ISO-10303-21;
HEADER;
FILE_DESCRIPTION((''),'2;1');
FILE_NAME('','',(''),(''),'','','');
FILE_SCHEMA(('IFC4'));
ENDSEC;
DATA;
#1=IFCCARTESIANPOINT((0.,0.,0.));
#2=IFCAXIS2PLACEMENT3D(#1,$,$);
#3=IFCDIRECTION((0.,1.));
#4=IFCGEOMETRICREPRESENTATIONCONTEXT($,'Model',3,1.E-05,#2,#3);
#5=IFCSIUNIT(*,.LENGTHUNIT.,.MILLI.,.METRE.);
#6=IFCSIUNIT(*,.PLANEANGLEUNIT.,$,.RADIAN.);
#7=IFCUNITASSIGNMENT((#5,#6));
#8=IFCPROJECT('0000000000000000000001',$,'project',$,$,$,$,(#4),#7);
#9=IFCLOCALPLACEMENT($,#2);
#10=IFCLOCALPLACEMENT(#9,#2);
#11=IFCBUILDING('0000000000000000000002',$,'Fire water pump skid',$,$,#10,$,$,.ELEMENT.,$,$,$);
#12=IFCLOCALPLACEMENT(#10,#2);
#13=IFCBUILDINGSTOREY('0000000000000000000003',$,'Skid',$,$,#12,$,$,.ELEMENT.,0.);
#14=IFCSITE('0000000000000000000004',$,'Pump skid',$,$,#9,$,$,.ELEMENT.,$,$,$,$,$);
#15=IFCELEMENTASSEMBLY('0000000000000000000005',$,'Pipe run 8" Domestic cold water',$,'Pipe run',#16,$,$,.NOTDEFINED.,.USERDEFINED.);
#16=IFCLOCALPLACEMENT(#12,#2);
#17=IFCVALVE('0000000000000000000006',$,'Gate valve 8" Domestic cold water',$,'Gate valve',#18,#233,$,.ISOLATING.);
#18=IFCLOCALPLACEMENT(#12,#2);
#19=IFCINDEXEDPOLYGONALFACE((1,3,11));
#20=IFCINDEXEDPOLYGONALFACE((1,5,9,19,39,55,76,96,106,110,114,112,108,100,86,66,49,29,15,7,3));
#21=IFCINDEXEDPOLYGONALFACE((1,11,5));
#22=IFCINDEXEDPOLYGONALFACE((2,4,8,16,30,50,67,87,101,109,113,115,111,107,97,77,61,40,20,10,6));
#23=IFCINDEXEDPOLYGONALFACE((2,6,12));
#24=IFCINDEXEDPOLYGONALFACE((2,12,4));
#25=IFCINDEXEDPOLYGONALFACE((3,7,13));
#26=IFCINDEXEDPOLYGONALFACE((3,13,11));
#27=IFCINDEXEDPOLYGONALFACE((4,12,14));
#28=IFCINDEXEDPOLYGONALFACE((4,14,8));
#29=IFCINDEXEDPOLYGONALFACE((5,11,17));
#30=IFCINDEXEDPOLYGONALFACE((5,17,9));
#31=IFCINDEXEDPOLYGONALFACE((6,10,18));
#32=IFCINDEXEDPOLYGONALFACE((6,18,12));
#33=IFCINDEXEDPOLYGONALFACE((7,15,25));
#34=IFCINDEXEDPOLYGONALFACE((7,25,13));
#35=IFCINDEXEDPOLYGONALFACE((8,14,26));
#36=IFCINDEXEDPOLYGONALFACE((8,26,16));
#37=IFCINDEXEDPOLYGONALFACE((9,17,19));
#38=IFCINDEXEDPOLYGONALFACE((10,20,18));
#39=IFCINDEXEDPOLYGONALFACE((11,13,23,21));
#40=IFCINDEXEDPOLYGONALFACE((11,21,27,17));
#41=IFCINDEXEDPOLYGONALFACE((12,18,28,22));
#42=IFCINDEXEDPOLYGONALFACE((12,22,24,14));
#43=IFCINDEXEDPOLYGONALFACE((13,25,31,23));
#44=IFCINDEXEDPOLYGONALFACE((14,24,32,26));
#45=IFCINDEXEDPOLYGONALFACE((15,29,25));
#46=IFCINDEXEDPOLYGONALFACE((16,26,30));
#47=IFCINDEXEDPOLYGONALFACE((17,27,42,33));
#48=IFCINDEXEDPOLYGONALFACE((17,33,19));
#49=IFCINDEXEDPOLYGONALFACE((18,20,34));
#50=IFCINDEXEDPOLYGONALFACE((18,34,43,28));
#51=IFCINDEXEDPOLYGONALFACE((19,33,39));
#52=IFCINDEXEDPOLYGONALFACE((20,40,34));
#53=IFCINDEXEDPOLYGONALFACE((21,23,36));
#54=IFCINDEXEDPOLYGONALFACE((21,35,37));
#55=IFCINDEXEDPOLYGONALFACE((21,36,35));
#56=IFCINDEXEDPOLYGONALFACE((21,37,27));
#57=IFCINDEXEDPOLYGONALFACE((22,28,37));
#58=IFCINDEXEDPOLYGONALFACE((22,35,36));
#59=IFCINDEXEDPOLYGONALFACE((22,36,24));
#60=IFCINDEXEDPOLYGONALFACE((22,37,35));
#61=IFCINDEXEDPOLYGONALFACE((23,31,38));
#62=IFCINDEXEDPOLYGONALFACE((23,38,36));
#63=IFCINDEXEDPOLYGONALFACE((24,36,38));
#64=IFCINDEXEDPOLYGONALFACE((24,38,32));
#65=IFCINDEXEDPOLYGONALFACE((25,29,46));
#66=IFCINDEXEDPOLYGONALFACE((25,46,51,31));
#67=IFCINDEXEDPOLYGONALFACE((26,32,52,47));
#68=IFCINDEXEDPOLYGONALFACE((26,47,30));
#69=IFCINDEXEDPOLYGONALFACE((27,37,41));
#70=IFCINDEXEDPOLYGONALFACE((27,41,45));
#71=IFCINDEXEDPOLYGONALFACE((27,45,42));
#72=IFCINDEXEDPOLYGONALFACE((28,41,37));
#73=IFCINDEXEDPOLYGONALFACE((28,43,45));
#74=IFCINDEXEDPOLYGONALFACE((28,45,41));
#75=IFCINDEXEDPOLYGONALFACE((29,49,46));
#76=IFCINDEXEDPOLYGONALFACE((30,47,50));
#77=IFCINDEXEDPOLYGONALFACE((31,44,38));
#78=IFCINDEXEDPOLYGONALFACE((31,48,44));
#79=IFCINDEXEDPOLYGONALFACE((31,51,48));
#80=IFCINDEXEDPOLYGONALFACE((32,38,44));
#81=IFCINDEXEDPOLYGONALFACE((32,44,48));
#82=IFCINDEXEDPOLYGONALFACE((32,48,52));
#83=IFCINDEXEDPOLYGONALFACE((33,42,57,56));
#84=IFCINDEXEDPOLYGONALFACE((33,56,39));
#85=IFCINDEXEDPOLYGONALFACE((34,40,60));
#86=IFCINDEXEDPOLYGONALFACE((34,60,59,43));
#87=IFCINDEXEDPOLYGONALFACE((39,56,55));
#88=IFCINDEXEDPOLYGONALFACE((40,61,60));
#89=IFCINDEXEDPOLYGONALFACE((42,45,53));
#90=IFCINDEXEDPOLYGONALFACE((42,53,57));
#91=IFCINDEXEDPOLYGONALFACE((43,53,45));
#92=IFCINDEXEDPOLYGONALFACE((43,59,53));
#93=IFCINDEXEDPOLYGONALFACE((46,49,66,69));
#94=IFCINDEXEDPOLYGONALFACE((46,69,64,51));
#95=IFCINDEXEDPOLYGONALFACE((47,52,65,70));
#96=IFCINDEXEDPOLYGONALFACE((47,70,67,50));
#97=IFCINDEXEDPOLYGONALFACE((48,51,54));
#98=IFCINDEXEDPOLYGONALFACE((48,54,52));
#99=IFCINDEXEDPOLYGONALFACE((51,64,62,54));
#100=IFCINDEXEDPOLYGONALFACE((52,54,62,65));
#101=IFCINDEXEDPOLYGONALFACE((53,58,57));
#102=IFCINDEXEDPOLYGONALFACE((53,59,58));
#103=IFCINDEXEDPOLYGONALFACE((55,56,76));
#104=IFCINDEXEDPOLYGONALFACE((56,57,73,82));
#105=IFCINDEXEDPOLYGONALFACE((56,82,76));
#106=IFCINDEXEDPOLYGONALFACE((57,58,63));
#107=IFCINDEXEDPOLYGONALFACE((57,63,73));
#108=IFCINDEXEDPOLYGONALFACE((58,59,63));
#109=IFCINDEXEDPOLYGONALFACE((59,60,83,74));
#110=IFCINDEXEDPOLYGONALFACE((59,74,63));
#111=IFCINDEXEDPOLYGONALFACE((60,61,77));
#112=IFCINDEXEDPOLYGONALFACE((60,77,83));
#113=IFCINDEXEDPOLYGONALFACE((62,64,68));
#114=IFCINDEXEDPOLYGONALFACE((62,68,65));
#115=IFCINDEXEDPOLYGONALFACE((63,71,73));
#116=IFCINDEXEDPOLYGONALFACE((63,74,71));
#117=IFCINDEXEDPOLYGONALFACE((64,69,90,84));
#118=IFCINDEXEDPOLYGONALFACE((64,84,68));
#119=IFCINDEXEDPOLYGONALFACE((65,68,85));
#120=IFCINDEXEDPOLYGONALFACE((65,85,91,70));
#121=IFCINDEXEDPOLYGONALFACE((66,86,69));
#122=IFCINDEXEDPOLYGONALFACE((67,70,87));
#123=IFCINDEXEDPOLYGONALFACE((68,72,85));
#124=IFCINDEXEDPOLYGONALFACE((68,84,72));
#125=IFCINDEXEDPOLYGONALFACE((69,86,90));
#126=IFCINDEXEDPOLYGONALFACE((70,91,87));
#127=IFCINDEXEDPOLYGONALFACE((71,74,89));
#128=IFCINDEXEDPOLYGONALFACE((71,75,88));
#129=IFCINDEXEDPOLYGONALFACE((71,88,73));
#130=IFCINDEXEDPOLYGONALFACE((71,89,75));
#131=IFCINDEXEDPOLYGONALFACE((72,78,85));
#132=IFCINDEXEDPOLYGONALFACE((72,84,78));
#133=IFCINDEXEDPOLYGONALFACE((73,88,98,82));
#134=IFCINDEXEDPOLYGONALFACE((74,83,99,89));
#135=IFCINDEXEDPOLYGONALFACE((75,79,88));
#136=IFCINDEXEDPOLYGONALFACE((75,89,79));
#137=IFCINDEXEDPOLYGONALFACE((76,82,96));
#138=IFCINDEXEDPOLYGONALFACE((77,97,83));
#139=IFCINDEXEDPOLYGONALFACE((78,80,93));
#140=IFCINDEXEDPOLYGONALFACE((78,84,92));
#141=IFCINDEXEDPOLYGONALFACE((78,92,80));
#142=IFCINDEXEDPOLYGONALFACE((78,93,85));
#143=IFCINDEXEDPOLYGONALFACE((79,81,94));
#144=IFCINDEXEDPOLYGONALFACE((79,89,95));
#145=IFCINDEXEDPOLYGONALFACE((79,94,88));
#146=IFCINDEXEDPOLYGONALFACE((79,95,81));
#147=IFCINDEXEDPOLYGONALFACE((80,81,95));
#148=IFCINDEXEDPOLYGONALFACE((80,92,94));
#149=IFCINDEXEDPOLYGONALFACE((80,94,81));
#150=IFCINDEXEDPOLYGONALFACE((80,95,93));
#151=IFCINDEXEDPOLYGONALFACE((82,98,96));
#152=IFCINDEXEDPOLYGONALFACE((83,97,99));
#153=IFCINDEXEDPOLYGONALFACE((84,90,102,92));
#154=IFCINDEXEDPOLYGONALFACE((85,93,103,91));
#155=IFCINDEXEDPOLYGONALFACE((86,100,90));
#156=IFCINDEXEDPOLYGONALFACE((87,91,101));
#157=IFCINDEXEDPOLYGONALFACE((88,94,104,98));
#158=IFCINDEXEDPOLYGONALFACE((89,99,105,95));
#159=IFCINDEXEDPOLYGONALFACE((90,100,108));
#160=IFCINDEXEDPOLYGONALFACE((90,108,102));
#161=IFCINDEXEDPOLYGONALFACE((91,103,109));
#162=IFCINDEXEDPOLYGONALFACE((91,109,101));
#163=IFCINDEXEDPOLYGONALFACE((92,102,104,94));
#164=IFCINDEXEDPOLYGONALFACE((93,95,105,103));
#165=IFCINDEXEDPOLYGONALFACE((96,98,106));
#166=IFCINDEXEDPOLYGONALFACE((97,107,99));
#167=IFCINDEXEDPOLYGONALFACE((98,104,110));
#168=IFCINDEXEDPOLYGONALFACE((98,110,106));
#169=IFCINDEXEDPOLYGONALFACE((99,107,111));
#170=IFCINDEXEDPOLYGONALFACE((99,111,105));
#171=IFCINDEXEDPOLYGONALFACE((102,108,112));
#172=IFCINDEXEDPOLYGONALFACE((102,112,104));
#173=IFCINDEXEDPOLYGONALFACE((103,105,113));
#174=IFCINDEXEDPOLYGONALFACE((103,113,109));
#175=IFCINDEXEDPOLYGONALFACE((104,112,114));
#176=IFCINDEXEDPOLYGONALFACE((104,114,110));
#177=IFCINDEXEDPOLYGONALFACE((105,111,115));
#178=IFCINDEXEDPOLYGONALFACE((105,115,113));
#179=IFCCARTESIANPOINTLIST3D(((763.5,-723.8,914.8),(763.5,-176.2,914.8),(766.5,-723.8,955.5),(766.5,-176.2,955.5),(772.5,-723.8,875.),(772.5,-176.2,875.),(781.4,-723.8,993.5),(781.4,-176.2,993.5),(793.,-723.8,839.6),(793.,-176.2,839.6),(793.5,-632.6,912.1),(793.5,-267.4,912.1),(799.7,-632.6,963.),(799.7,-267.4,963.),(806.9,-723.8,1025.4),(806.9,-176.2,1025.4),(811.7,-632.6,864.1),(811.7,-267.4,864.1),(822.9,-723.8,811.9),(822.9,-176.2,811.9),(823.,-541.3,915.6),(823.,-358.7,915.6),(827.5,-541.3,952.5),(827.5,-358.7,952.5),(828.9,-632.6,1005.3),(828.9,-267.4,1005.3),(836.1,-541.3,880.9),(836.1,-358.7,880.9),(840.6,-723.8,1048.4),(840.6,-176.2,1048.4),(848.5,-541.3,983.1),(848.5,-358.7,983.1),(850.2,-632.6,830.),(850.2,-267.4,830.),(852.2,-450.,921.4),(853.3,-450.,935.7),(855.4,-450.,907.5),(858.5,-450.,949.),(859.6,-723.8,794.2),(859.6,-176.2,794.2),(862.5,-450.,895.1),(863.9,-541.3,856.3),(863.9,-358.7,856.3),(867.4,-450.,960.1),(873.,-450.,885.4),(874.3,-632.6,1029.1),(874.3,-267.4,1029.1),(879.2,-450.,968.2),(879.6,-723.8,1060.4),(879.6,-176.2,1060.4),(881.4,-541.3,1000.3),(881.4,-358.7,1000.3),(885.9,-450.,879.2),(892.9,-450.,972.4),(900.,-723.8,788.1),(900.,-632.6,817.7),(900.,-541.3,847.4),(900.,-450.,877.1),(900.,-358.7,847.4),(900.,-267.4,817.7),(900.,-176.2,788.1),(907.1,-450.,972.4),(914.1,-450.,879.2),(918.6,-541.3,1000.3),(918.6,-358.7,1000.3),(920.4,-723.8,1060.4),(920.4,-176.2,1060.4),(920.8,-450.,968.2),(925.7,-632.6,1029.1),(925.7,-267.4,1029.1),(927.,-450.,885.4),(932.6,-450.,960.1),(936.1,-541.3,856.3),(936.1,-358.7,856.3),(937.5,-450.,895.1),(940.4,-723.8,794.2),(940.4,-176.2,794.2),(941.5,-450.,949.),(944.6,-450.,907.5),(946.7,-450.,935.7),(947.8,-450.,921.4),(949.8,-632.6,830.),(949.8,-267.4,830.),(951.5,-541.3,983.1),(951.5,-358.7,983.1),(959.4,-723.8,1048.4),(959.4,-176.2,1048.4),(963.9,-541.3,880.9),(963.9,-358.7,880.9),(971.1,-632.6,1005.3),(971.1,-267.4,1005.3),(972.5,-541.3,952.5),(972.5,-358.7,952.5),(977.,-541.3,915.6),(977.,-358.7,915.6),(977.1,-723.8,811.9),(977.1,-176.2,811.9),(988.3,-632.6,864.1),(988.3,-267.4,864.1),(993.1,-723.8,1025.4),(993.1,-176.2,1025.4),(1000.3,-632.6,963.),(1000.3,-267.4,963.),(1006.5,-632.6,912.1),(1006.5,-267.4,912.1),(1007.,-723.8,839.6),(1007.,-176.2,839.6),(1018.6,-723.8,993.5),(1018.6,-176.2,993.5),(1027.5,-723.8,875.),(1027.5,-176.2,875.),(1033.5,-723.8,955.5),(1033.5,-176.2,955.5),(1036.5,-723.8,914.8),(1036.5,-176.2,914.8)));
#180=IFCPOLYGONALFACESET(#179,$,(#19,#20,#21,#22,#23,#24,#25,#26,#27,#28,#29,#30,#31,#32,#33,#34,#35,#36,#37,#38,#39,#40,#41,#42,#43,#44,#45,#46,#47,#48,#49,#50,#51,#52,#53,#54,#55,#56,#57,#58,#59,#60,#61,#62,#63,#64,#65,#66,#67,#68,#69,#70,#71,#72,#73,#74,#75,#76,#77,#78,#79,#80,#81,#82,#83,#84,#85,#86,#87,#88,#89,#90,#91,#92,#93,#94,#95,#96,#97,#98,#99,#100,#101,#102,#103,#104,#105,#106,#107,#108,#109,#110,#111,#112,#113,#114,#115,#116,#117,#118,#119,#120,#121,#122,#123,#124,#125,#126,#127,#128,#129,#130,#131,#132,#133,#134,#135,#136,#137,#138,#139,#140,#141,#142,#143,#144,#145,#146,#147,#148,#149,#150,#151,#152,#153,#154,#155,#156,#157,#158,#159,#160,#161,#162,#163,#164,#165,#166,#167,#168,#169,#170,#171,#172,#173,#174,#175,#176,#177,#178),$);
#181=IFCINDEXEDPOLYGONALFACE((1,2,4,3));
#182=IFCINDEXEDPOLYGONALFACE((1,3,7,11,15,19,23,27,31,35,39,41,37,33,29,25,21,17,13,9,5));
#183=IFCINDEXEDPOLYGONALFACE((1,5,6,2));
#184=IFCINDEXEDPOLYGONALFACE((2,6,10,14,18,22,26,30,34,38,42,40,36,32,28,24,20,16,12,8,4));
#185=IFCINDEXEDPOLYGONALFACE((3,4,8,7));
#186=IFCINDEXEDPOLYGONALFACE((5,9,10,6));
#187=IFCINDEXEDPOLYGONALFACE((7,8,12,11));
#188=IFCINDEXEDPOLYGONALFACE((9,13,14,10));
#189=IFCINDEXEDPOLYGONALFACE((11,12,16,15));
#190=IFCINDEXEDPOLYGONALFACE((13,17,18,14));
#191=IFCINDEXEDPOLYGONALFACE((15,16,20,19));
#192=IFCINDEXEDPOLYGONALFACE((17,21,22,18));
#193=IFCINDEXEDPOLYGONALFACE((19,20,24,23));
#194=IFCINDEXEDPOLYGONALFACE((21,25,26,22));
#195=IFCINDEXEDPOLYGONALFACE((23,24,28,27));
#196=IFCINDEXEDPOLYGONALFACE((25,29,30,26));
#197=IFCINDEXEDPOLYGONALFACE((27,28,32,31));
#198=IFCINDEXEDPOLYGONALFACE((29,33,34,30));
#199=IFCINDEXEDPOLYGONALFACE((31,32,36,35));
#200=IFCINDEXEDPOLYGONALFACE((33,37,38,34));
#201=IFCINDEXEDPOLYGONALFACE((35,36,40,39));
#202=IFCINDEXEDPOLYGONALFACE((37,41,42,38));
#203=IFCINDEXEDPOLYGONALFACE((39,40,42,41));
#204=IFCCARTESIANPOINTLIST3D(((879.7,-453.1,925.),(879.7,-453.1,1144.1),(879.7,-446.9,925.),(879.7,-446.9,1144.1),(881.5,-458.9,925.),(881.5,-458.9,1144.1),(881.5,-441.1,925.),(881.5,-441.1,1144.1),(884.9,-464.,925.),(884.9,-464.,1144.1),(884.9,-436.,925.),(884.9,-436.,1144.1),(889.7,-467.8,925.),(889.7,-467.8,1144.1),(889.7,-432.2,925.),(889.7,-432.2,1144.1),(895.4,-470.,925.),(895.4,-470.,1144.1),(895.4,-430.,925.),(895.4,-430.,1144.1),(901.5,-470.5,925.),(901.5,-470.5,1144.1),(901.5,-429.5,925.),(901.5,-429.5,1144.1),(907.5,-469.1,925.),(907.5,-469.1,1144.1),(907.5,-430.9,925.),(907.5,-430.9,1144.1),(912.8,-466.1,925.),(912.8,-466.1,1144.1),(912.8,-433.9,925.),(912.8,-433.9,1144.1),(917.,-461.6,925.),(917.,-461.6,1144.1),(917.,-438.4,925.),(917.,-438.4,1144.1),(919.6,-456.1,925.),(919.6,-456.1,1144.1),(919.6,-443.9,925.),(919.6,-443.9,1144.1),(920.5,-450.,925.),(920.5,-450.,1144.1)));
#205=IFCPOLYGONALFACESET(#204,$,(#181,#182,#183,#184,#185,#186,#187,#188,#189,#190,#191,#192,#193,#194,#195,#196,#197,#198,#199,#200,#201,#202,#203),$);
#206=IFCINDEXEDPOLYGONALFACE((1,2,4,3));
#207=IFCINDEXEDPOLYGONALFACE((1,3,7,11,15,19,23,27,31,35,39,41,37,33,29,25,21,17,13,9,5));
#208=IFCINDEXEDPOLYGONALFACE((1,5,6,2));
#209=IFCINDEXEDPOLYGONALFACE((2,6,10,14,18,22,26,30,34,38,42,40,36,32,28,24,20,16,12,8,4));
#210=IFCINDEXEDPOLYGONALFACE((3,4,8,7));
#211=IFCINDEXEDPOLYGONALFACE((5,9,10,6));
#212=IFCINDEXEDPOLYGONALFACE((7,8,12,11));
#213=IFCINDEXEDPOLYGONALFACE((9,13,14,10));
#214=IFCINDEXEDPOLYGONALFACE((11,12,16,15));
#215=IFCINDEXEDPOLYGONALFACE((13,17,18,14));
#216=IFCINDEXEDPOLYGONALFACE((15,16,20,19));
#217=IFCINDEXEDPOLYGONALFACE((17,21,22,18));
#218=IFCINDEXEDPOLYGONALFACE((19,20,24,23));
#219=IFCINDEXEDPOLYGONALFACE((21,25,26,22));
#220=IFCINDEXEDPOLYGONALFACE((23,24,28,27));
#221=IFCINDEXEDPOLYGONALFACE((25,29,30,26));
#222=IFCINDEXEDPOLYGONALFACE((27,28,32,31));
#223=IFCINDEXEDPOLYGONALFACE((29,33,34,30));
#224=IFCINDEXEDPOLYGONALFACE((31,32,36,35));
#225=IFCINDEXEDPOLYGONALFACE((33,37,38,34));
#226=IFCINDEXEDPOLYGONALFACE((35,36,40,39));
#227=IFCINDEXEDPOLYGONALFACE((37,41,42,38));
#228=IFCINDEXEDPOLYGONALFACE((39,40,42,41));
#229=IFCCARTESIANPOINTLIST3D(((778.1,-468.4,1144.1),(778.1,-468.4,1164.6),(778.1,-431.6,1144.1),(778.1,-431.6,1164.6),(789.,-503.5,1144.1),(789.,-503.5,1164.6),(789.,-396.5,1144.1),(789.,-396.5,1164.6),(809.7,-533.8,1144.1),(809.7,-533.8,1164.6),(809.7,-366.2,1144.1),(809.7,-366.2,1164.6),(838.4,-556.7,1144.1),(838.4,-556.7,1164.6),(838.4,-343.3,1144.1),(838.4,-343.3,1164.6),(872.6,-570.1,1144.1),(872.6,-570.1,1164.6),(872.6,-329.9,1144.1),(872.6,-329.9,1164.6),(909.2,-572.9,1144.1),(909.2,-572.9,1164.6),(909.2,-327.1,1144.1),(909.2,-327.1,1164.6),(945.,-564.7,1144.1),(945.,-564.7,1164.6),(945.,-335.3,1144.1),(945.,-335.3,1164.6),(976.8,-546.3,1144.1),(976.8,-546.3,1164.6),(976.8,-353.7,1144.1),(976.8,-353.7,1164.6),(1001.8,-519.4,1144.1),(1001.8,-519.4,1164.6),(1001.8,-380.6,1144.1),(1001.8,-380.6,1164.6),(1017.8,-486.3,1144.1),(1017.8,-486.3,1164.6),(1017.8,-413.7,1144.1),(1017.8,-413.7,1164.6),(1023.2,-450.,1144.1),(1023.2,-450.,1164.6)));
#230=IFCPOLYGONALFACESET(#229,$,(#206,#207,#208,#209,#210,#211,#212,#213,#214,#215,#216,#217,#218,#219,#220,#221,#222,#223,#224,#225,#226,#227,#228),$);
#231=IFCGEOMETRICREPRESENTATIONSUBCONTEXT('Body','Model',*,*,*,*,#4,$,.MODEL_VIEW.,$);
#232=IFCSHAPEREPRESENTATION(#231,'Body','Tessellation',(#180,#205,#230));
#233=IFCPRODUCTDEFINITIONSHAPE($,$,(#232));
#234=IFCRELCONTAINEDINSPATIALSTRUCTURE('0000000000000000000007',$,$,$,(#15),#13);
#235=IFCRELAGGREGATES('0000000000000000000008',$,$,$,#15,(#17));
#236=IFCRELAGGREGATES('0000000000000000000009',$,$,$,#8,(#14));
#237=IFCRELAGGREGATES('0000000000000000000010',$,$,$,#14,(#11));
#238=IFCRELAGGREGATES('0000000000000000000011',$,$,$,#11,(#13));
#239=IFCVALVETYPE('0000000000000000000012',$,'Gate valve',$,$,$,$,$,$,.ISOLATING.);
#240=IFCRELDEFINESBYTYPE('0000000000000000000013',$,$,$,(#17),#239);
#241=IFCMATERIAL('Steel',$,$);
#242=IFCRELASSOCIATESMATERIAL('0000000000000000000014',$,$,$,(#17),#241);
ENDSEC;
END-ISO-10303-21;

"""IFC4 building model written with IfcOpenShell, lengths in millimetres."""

from ifc_helpers import new_model, entity, si_unit, direction, frame, origin, origin_with_axes, origin_2d, place, context, subcontext, project, spatial, circle, extrude, material, type_object, element, aggregate, save


model = new_model("IFC4")

# Units and contexts
model_context = context("Model", 3, precision=1e-05, world=origin(), true_north=direction((0.0, 1.0)))
body_context = subcontext(model_context, "Body", "Model", "MODEL_VIEW")
ifc_project = project(units=[si_unit("LENGTHUNIT", "METRE", prefix="MILLI"), si_unit("PLANEANGLEUNIT", "RADIAN")], contexts=[model_context])

# Site, building, storey
site_placement = place(None, origin())
site = spatial("IfcSite", under=ifc_project, at=site_placement, Name="Pump skid", CompositionType="ELEMENT")
building_placement = place(site_placement, origin())
building = spatial("IfcBuilding", under=site, at=building_placement, Name="Fire water pump skid", CompositionType="ELEMENT")
storey_placement = place(building_placement, origin())
storey = spatial("IfcBuildingStorey", under=building, at=storey_placement, Name="Skid", CompositionType="ELEMENT", Elevation=0.0)

# Element assembly
ifc_material = material(Name="Steel")
assembly_1_placement = place(storey_placement, origin_with_axes())
assembly_1 = element("IfcElementAssembly", 1, at=assembly_1_placement, inside=storey, Name="Pipe run 8\" Domestic cold water", ObjectType="Pipe run", AssemblyPlace="NOTDEFINED", PredefinedType="USERDEFINED")

# Valve
valve_type_1 = type_object("IfcValveType", Name="Gate valve", PredefinedType="ISOLATING")
valve_1_placement = place(storey_placement, origin_with_axes())
cartesian_point_1 = entity("IfcCartesianPoint", [0.0, 0.0])
valve_1 = element("IfcValve", 2, at=valve_1_placement, type_object=valve_type_1, material=ifc_material, Name="Gate valve 8\" Domestic cold water", ObjectType="Gate valve", PredefinedType="ISOLATING", context=body_context, shape_type="SweptSolid", body=[
    entity("IfcRevolvedAreaSolid", entity("IfcArbitraryClosedProfileDef", "AREA", None, entity("IfcPolyline", [cartesian_point_1, entity("IfcCartesianPoint", [0.0, 136.9]), entity("IfcCartesianPoint", [273.8, 47.9]), entity("IfcCartesianPoint", [547.7, 136.9]), entity("IfcCartesianPoint", [547.7, 0.0]), cartesian_point_1])), entity("IfcAxis2Placement3D", entity("IfcCartesianPoint", [900.0, -723.8, 925.0]), entity("IfcDirection", [-1.0, 0.0, 0.0]), entity("IfcDirection", [0.0, 1.0, 0.0])), entity("IfcAxis1Placement", entity("IfcCartesianPoint", [0.0, 0.0, 0.0]), entity("IfcDirection", [1.0, 0.0, 0.0])), 6.283185),
    extrude(circle(Radius=20.5, at=origin_2d()), frame((900.0, -450.0, 925.0), z_axis=(0.0, 0.0, 1.0), x_axis=(1.0, 0.0, 0.0)), (0.0, 0.0, 1.0), 219.1),
    extrude(circle(Radius=123.2, at=origin_2d()), frame((900.0, -450.0, 1144.1), z_axis=(0.0, 0.0, 1.0), x_axis=(1.0, 0.0, 0.0)), (0.0, 0.0, 1.0), 20.5),
])

aggregate(assembly_1, [valve_1])

save(model, "model.ifc")
